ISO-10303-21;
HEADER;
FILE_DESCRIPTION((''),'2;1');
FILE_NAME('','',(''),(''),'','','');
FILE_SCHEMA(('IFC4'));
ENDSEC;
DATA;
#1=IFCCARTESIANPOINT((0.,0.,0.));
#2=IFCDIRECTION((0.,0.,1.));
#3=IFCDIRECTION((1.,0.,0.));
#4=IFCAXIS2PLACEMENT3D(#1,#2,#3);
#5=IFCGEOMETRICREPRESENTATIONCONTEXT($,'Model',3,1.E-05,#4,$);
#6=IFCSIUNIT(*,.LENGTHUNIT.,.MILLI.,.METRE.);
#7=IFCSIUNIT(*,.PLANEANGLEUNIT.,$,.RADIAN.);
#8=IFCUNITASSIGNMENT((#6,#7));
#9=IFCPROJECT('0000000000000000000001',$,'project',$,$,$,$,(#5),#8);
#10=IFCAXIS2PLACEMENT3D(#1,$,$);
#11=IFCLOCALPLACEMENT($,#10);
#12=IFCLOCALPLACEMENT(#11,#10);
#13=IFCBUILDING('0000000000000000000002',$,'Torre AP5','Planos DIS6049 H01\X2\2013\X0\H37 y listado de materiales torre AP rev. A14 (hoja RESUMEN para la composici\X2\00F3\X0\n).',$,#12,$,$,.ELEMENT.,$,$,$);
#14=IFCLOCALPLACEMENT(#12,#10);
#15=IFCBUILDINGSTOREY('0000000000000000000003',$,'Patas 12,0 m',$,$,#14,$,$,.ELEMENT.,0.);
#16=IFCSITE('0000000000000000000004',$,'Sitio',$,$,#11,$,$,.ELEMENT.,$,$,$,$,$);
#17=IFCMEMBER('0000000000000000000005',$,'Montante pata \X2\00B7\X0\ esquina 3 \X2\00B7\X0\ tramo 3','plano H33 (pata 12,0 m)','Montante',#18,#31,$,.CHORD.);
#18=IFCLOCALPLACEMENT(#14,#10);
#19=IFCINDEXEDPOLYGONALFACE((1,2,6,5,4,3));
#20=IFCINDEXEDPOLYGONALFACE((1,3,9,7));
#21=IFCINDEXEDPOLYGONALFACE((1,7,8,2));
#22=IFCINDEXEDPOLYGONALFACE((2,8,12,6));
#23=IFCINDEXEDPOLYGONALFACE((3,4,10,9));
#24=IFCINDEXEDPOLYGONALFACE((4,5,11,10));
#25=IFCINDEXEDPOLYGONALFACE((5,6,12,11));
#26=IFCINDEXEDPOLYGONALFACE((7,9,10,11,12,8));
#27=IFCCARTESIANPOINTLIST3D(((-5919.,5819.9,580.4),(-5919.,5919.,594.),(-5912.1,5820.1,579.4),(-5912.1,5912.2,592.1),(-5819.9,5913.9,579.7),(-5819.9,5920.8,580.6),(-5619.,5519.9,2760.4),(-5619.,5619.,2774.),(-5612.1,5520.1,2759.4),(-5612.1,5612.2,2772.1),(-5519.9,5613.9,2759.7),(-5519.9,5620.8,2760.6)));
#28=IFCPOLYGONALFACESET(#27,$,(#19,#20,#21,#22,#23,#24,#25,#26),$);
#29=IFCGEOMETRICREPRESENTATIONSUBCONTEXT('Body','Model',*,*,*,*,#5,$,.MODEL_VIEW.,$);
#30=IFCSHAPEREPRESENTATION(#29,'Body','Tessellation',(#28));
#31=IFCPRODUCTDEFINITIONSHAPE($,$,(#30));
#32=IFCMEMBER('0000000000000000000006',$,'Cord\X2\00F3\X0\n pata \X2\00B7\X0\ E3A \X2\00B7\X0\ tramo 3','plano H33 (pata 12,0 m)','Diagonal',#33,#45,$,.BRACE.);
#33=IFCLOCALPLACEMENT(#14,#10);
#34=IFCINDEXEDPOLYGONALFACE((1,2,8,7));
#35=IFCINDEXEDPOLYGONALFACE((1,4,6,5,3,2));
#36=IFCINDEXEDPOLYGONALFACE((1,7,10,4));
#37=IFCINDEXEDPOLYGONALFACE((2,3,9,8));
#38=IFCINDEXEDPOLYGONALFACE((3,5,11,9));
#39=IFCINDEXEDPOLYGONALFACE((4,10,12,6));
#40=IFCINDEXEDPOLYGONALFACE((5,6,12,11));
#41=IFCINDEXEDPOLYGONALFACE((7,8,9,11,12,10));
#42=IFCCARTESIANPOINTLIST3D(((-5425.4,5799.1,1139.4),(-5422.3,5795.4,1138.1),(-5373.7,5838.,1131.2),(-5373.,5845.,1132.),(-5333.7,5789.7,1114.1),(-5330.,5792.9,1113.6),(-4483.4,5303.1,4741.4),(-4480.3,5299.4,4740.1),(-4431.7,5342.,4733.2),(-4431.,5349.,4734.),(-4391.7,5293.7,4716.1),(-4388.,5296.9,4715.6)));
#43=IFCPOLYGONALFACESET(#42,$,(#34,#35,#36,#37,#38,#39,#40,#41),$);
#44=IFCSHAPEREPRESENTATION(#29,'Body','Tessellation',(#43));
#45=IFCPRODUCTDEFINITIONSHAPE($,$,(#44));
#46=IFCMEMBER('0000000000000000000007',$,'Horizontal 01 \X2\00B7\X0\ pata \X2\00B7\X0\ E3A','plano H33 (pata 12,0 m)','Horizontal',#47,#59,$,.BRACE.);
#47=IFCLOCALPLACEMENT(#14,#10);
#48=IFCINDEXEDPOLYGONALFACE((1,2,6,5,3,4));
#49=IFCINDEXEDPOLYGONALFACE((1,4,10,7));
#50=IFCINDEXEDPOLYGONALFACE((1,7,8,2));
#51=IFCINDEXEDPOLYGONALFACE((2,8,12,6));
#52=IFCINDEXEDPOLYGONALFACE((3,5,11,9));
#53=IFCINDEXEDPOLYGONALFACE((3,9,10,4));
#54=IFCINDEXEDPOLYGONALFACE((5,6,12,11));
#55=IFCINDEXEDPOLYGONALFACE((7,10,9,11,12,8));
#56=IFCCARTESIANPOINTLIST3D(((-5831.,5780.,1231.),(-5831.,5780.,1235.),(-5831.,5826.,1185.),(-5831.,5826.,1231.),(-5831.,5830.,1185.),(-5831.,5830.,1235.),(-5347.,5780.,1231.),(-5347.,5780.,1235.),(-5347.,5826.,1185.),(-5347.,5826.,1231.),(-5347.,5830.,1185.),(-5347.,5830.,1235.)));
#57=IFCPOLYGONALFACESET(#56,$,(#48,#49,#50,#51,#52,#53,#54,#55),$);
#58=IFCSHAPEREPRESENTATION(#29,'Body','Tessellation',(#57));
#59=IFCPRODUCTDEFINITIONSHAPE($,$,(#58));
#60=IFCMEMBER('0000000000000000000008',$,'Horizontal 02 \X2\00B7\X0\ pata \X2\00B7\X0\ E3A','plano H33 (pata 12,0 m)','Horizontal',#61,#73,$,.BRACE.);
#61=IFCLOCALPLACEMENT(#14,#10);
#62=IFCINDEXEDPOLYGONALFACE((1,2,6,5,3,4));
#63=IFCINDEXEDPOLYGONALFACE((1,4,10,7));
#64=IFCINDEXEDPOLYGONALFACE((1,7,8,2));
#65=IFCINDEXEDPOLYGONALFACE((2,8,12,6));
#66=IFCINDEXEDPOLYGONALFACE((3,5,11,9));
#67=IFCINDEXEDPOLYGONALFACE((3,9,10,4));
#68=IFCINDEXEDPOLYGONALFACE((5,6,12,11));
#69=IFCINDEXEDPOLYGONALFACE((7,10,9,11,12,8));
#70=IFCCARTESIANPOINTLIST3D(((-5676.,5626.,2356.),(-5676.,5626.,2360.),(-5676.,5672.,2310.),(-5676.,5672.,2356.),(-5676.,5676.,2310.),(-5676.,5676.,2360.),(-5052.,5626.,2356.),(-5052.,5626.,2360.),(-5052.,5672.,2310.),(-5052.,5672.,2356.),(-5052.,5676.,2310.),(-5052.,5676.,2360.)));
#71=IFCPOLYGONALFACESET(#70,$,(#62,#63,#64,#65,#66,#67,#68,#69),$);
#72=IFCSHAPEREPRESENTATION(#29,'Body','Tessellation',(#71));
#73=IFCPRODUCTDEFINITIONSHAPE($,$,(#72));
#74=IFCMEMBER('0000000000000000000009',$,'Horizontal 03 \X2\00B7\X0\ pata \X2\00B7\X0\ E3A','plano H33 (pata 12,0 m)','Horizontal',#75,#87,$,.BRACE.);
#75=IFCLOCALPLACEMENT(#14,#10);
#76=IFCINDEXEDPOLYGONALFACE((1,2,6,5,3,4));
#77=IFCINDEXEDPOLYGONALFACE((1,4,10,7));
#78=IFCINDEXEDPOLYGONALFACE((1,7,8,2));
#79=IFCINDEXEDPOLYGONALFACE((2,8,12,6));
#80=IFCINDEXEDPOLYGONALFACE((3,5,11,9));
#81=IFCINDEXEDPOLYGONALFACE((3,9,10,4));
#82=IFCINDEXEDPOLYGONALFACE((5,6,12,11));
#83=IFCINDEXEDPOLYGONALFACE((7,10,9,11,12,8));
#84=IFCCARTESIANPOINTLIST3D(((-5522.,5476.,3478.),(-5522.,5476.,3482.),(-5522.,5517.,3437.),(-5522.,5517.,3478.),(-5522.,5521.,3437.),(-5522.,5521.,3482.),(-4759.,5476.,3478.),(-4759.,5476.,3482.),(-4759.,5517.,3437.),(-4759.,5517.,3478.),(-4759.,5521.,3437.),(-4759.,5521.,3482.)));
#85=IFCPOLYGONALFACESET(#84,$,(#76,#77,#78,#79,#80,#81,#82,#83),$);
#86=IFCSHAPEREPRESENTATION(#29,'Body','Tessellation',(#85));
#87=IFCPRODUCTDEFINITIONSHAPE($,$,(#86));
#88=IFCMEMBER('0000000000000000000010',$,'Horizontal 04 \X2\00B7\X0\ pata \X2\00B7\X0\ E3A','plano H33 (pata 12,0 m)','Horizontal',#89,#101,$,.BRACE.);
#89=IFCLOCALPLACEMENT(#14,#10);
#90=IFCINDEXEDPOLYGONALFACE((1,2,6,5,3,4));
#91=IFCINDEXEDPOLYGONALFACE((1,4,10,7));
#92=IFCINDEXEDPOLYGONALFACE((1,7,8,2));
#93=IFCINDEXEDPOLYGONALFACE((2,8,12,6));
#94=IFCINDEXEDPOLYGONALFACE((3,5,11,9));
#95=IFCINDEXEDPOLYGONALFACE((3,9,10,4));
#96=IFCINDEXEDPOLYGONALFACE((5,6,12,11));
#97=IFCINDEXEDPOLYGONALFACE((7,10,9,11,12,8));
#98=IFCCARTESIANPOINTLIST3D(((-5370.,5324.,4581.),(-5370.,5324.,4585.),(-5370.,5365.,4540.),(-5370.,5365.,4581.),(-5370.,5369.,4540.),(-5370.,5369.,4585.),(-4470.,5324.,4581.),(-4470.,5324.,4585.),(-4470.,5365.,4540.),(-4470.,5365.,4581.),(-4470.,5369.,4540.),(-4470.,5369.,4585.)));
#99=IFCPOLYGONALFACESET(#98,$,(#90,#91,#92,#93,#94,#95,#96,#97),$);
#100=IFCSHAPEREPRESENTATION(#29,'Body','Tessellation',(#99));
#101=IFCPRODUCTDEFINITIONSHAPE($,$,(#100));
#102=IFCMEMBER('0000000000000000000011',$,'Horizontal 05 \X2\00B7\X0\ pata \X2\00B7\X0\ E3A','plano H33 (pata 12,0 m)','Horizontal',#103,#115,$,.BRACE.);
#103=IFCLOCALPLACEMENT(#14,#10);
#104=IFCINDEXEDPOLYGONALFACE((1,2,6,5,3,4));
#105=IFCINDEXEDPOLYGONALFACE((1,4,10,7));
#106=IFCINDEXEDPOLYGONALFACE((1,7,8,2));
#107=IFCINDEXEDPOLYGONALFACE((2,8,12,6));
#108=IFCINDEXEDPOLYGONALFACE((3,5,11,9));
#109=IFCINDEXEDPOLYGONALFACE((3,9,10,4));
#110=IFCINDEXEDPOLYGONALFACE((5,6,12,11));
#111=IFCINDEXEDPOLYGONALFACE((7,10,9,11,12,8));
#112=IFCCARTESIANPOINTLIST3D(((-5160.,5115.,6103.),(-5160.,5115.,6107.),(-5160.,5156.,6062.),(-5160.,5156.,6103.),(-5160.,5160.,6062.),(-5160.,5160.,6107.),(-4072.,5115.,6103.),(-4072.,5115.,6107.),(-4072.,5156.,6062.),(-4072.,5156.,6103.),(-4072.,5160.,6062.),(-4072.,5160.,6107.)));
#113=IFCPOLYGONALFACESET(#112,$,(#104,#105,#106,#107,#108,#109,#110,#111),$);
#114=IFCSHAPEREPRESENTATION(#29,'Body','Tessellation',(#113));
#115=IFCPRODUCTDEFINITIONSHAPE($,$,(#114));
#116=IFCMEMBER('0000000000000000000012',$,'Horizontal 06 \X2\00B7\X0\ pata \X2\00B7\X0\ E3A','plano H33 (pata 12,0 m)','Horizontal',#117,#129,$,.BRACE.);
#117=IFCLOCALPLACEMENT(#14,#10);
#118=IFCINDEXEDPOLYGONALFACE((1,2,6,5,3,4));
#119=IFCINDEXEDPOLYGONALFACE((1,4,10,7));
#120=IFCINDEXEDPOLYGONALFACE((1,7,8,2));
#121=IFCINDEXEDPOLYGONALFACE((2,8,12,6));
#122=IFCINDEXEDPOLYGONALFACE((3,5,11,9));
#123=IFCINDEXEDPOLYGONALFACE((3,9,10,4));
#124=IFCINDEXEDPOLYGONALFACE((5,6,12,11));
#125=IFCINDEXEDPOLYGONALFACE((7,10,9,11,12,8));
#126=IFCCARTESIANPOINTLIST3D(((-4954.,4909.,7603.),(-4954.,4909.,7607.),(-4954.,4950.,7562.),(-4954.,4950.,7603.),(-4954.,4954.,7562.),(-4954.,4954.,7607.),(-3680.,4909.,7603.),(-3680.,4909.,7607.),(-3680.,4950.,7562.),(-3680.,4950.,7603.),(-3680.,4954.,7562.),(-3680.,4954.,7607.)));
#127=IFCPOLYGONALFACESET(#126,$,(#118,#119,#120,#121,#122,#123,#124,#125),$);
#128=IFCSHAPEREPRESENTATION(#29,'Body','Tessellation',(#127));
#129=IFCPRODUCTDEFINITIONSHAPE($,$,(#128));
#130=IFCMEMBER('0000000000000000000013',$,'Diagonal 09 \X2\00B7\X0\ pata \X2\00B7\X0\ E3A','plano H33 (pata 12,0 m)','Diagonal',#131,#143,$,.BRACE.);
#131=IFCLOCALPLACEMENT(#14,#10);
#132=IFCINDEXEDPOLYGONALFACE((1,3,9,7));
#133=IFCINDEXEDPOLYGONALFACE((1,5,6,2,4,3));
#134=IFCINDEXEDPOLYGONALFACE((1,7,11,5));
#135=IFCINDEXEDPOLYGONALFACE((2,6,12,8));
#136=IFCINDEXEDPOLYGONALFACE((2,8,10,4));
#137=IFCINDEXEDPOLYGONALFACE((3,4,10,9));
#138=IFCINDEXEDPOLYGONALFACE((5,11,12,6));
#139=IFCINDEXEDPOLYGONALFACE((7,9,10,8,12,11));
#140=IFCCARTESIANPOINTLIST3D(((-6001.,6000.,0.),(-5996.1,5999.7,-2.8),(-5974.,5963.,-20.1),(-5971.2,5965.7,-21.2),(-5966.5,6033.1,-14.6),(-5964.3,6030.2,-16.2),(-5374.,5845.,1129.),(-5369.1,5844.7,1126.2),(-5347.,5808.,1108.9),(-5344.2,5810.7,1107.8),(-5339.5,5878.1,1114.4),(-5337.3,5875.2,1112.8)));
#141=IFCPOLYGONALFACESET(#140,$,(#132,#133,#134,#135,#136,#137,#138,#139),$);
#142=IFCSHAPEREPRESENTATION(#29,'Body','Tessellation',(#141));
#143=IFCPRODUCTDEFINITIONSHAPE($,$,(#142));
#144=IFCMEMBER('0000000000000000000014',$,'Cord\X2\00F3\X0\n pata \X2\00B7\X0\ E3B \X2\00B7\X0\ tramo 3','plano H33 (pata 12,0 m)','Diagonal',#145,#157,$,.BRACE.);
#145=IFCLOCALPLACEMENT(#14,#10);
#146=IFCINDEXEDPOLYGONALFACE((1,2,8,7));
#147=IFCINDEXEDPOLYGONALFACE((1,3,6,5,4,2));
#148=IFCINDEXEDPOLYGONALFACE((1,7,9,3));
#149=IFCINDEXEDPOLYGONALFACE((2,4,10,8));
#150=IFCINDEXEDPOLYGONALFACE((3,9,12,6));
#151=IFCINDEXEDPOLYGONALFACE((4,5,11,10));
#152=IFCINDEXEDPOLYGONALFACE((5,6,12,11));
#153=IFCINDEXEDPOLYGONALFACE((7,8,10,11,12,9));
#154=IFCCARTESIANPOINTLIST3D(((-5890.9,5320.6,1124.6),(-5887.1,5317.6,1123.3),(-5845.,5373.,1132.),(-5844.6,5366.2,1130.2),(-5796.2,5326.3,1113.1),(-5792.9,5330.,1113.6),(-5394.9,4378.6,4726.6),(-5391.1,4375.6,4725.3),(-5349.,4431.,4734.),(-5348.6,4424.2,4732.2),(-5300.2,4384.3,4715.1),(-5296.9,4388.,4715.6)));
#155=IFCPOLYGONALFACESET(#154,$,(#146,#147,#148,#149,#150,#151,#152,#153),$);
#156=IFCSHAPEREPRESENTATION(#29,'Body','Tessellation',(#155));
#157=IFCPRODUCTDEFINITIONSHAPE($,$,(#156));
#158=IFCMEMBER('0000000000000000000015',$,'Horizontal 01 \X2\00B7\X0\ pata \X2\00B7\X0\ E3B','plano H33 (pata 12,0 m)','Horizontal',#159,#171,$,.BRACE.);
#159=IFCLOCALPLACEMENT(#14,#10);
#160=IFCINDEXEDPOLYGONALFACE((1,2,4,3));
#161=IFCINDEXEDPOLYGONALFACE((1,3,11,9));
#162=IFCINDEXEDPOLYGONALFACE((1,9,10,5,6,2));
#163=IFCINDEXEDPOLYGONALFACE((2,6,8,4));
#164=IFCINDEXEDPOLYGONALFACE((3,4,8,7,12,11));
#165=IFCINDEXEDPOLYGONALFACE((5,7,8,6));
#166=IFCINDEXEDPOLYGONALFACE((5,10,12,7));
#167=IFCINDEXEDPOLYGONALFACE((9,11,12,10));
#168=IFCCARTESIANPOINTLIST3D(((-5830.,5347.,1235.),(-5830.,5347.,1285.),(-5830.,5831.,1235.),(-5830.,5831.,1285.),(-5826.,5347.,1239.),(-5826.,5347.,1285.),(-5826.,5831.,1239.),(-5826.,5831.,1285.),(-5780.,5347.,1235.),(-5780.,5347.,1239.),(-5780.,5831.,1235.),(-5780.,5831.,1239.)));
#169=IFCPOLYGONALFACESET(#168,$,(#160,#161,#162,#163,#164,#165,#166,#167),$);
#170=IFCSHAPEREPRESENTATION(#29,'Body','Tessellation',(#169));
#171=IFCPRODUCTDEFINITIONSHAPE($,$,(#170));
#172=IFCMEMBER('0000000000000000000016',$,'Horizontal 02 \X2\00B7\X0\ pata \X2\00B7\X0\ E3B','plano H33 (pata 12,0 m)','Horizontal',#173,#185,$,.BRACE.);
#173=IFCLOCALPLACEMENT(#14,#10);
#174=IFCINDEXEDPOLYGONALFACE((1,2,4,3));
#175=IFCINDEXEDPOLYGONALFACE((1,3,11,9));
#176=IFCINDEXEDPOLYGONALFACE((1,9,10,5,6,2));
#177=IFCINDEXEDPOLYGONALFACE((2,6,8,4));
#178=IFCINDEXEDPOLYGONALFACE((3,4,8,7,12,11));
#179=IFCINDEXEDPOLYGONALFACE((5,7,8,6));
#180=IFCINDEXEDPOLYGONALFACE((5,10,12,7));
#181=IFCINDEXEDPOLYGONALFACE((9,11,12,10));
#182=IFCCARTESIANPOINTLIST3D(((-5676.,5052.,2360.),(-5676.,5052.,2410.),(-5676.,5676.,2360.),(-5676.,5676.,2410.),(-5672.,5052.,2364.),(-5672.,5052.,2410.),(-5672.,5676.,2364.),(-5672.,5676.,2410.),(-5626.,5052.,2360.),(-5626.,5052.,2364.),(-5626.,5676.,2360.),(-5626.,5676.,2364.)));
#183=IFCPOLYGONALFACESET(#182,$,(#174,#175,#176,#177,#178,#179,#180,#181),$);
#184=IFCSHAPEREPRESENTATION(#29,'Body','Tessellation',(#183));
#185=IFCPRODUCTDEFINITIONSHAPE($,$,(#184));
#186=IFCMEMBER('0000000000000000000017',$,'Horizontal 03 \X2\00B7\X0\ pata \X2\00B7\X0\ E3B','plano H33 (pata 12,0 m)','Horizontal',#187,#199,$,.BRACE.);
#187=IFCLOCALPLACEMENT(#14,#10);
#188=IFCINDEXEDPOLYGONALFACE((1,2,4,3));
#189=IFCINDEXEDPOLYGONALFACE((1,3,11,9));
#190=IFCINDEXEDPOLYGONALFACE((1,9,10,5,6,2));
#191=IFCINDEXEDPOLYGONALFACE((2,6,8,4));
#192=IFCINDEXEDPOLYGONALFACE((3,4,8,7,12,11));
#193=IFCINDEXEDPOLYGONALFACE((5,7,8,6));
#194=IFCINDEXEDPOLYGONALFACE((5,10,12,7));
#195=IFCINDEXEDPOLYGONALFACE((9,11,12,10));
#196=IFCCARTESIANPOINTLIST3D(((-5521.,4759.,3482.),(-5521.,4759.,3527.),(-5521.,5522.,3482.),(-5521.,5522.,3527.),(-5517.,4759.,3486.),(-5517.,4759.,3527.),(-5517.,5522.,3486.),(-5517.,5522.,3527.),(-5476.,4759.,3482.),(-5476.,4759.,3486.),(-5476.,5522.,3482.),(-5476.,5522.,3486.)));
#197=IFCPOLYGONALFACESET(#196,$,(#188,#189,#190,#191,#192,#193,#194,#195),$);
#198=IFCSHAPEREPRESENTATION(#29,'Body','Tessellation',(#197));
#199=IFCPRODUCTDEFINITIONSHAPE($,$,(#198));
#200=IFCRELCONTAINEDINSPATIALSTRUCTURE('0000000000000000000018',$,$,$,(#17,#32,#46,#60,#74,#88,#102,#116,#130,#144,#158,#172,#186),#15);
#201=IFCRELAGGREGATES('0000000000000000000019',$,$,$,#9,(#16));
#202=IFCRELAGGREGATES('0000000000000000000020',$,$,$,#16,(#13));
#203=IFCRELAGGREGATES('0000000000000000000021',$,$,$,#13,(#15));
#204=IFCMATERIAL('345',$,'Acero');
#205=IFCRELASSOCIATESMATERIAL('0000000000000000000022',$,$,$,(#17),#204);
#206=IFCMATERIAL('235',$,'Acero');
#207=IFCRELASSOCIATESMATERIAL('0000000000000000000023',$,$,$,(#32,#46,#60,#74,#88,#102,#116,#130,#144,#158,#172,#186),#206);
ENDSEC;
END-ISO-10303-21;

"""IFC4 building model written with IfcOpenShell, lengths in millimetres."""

from ifc_helpers import new_model, si_unit, frame, frame_2d, origin, origin_with_axes, place, context, subcontext, project, spatial, l_section, extrude, material, element, save


model = new_model("IFC4")

# Units and contexts
model_context = context("Model", 3, precision=1e-05, world=origin_with_axes())
body_context = subcontext(model_context, "Body", "Model", "MODEL_VIEW")
ifc_project = project(units=[si_unit("LENGTHUNIT", "METRE", prefix="MILLI"), si_unit("PLANEANGLEUNIT", "RADIAN")], contexts=[model_context])

# Site, building, storey
site_placement = place(None, origin())
site = spatial("IfcSite", under=ifc_project, at=site_placement, Name="Sitio", CompositionType="ELEMENT")
building_placement = place(site_placement, origin())
building = spatial("IfcBuilding", under=site, at=building_placement, Name="Torre AP5", Description="Planos DIS6049 H01–H37 y listado de materiales torre AP rev. A14 (hoja RESUMEN para la composición).", CompositionType="ELEMENT")
storey_placement = place(building_placement, origin())
storey = spatial("IfcBuildingStorey", under=building, at=storey_placement, Name="Patas 12,0 m", CompositionType="ELEMENT", Elevation=0.0)

# Members
ifc_material_1 = material(Name="345", Category="Acero")
member_1_placement = place(storey_placement, frame((-5619.0, 5619.0, 2774.0), z_axis=(-0.13508, 0.13508, -0.981584), x_axis=(0.990835, 0.018415, -0.133819)))
element("IfcMember", 1, at=member_1_placement, inside=storey, material=ifc_material_1, Name="Montante pata · esquina 3 · tramo 3", Description="plano H33 (pata 12,0 m)", ObjectType="Montante", PredefinedType="CHORD", context=body_context, shape_type="SweptSolid", body=[
    extrude(l_section(Depth=100.0, Width=100.0, Thickness=7.0, at=frame_2d((50.0, 50.0))), None, (0.0, 0.0, 1.0), 2220.9),
])
ifc_material_2 = material(Name="235", Category="Acero")
member_2_placement = place(storey_placement, frame((-4431.0, 5349.0, 4734.0), z_axis=(-0.250797, 0.132054, -0.958991), x_axis=(0.614396, -0.743837, -0.263105)))
element("IfcMember", 2, at=member_2_placement, inside=storey, material=ifc_material_2, Name="Cordón pata · E3A · tramo 3", Description="plano H33 (pata 12,0 m)", ObjectType="Diagonal", PredefinedType="BRACE", context=body_context, shape_type="SweptSolid", body=[
    extrude(l_section(Depth=70.0, Width=70.0, Thickness=5.0, at=frame_2d((35.0, 35.0))), None, (0.0, 0.0, 1.0), 3756.0),
])
member_3_placement = place(storey_placement, frame((-5831.0, 5830.0, 1235.0), z_axis=(1.0, 0.0, 0.0), x_axis=(0.0, -1.0, 0.0)))
element("IfcMember", 3, at=member_3_placement, inside=storey, material=ifc_material_2, Name="Horizontal 01 · pata · E3A", Description="plano H33 (pata 12,0 m)", ObjectType="Horizontal", PredefinedType="BRACE", context=body_context, shape_type="SweptSolid", body=[
    extrude(l_section(Depth=50.0, Width=50.0, Thickness=4.0, at=frame_2d((25.0, 25.0))), None, (0.0, 0.0, 1.0), 484.0),
])
member_4_placement = place(storey_placement, frame((-5676.0, 5676.0, 2360.0), z_axis=(1.0, 0.0, 0.0), x_axis=(0.0, -1.0, 0.0)))
element("IfcMember", 4, at=member_4_placement, inside=storey, material=ifc_material_2, Name="Horizontal 02 · pata · E3A", Description="plano H33 (pata 12,0 m)", ObjectType="Horizontal", PredefinedType="BRACE", context=body_context, shape_type="SweptSolid", body=[
    extrude(l_section(Depth=50.0, Width=50.0, Thickness=4.0, at=frame_2d((25.0, 25.0))), None, (0.0, 0.0, 1.0), 624.0),
])
member_5_placement = place(storey_placement, frame((-5522.0, 5521.0, 3482.0), z_axis=(1.0, 0.0, 0.0), x_axis=(0.0, -1.0, 0.0)))
element("IfcMember", 5, at=member_5_placement, inside=storey, material=ifc_material_2, Name="Horizontal 03 · pata · E3A", Description="plano H33 (pata 12,0 m)", ObjectType="Horizontal", PredefinedType="BRACE", context=body_context, shape_type="SweptSolid", body=[
    extrude(l_section(Depth=45.0, Width=45.0, Thickness=4.0, at=frame_2d((22.5, 22.5))), None, (0.0, 0.0, 1.0), 763.0),
])
member_6_placement = place(storey_placement, frame((-5370.0, 5369.0, 4585.0), z_axis=(1.0, 0.0, 0.0), x_axis=(0.0, -1.0, 0.0)))
element("IfcMember", 6, at=member_6_placement, inside=storey, material=ifc_material_2, Name="Horizontal 04 · pata · E3A", Description="plano H33 (pata 12,0 m)", ObjectType="Horizontal", PredefinedType="BRACE", context=body_context, shape_type="SweptSolid", body=[
    extrude(l_section(Depth=45.0, Width=45.0, Thickness=4.0, at=frame_2d((22.5, 22.5))), None, (0.0, 0.0, 1.0), 900.0),
])
member_7_placement = place(storey_placement, frame((-5160.0, 5160.0, 6107.0), z_axis=(1.0, 0.0, 0.0), x_axis=(0.0, -1.0, 0.0)))
element("IfcMember", 7, at=member_7_placement, inside=storey, material=ifc_material_2, Name="Horizontal 05 · pata · E3A", Description="plano H33 (pata 12,0 m)", ObjectType="Horizontal", PredefinedType="BRACE", context=body_context, shape_type="SweptSolid", body=[
    extrude(l_section(Depth=45.0, Width=45.0, Thickness=4.0, at=frame_2d((22.5, 22.5))), None, (0.0, 0.0, 1.0), 1088.0),
])
member_8_placement = place(storey_placement, frame((-4954.0, 4954.0, 7607.0), z_axis=(1.0, 0.0, 0.0), x_axis=(0.0, -1.0, 0.0)))
element("IfcMember", 8, at=member_8_placement, inside=storey, material=ifc_material_2, Name="Horizontal 06 · pata · E3A", Description="plano H33 (pata 12,0 m)", ObjectType="Horizontal", PredefinedType="BRACE", context=body_context, shape_type="SweptSolid", body=[
    extrude(l_section(Depth=45.0, Width=45.0, Thickness=4.0, at=frame_2d((22.5, 22.5))), None, (0.0, 0.0, 1.0), 1274.0),
])
member_9_placement = place(storey_placement, frame((-6001.0, 6000.0, 0.0), z_axis=(0.482052, -0.119168, 0.868001), x_axis=(0.54018, -0.73958, -0.40153)))
element("IfcMember", 9, at=member_9_placement, inside=storey, material=ifc_material_2, Name="Diagonal 09 · pata · E3A", Description="plano H33 (pata 12,0 m)", ObjectType="Diagonal", PredefinedType="BRACE", context=body_context, shape_type="SweptSolid", body=[
    extrude(l_section(Depth=50.0, Width=50.0, Thickness=4.0, at=frame_2d((25.0, 25.0))), None, (0.0, 0.0, 1.0), 1300.7),
])
member_10_placement = place(storey_placement, frame((-5349.0, 4431.0, 4734.0), z_axis=(-0.132054, 0.250797, -0.958991), x_axis=(0.743837, -0.614396, -0.263105)))
element("IfcMember", 10, at=member_10_placement, inside=storey, material=ifc_material_2, Name="Cordón pata · E3B · tramo 3", Description="plano H33 (pata 12,0 m)", ObjectType="Diagonal", PredefinedType="BRACE", context=body_context, shape_type="SweptSolid", body=[
    extrude(l_section(Depth=70.0, Width=70.0, Thickness=5.0, at=frame_2d((35.0, 35.0))), None, (0.0, 0.0, 1.0), 3756.0),
])
member_11_placement = place(storey_placement, frame((-5830.0, 5831.0, 1235.0), z_axis=(0.0, -1.0, 0.0), x_axis=(1.0, 0.0, 0.0)))
element("IfcMember", 11, at=member_11_placement, inside=storey, material=ifc_material_2, Name="Horizontal 01 · pata · E3B", Description="plano H33 (pata 12,0 m)", ObjectType="Horizontal", PredefinedType="BRACE", context=body_context, shape_type="SweptSolid", body=[
    extrude(l_section(Depth=50.0, Width=50.0, Thickness=4.0, at=frame_2d((25.0, 25.0))), None, (0.0, 0.0, 1.0), 484.0),
])
member_12_placement = place(storey_placement, frame((-5676.0, 5676.0, 2360.0), z_axis=(0.0, -1.0, 0.0), x_axis=(1.0, 0.0, 0.0)))
element("IfcMember", 12, at=member_12_placement, inside=storey, material=ifc_material_2, Name="Horizontal 02 · pata · E3B", Description="plano H33 (pata 12,0 m)", ObjectType="Horizontal", PredefinedType="BRACE", context=body_context, shape_type="SweptSolid", body=[
    extrude(l_section(Depth=50.0, Width=50.0, Thickness=4.0, at=frame_2d((25.0, 25.0))), None, (0.0, 0.0, 1.0), 624.0),
])
member_13_placement = place(storey_placement, frame((-5521.0, 5522.0, 3482.0), z_axis=(0.0, -1.0, 0.0), x_axis=(1.0, 0.0, 0.0)))
element("IfcMember", 13, at=member_13_placement, inside=storey, material=ifc_material_2, Name="Horizontal 03 · pata · E3B", Description="plano H33 (pata 12,0 m)", ObjectType="Horizontal", PredefinedType="BRACE", context=body_context, shape_type="SweptSolid", body=[
    extrude(l_section(Depth=45.0, Width=45.0, Thickness=4.0, at=frame_2d((22.5, 22.5))), None, (0.0, 0.0, 1.0), 763.0),
])

save(model, "model.ifc")
